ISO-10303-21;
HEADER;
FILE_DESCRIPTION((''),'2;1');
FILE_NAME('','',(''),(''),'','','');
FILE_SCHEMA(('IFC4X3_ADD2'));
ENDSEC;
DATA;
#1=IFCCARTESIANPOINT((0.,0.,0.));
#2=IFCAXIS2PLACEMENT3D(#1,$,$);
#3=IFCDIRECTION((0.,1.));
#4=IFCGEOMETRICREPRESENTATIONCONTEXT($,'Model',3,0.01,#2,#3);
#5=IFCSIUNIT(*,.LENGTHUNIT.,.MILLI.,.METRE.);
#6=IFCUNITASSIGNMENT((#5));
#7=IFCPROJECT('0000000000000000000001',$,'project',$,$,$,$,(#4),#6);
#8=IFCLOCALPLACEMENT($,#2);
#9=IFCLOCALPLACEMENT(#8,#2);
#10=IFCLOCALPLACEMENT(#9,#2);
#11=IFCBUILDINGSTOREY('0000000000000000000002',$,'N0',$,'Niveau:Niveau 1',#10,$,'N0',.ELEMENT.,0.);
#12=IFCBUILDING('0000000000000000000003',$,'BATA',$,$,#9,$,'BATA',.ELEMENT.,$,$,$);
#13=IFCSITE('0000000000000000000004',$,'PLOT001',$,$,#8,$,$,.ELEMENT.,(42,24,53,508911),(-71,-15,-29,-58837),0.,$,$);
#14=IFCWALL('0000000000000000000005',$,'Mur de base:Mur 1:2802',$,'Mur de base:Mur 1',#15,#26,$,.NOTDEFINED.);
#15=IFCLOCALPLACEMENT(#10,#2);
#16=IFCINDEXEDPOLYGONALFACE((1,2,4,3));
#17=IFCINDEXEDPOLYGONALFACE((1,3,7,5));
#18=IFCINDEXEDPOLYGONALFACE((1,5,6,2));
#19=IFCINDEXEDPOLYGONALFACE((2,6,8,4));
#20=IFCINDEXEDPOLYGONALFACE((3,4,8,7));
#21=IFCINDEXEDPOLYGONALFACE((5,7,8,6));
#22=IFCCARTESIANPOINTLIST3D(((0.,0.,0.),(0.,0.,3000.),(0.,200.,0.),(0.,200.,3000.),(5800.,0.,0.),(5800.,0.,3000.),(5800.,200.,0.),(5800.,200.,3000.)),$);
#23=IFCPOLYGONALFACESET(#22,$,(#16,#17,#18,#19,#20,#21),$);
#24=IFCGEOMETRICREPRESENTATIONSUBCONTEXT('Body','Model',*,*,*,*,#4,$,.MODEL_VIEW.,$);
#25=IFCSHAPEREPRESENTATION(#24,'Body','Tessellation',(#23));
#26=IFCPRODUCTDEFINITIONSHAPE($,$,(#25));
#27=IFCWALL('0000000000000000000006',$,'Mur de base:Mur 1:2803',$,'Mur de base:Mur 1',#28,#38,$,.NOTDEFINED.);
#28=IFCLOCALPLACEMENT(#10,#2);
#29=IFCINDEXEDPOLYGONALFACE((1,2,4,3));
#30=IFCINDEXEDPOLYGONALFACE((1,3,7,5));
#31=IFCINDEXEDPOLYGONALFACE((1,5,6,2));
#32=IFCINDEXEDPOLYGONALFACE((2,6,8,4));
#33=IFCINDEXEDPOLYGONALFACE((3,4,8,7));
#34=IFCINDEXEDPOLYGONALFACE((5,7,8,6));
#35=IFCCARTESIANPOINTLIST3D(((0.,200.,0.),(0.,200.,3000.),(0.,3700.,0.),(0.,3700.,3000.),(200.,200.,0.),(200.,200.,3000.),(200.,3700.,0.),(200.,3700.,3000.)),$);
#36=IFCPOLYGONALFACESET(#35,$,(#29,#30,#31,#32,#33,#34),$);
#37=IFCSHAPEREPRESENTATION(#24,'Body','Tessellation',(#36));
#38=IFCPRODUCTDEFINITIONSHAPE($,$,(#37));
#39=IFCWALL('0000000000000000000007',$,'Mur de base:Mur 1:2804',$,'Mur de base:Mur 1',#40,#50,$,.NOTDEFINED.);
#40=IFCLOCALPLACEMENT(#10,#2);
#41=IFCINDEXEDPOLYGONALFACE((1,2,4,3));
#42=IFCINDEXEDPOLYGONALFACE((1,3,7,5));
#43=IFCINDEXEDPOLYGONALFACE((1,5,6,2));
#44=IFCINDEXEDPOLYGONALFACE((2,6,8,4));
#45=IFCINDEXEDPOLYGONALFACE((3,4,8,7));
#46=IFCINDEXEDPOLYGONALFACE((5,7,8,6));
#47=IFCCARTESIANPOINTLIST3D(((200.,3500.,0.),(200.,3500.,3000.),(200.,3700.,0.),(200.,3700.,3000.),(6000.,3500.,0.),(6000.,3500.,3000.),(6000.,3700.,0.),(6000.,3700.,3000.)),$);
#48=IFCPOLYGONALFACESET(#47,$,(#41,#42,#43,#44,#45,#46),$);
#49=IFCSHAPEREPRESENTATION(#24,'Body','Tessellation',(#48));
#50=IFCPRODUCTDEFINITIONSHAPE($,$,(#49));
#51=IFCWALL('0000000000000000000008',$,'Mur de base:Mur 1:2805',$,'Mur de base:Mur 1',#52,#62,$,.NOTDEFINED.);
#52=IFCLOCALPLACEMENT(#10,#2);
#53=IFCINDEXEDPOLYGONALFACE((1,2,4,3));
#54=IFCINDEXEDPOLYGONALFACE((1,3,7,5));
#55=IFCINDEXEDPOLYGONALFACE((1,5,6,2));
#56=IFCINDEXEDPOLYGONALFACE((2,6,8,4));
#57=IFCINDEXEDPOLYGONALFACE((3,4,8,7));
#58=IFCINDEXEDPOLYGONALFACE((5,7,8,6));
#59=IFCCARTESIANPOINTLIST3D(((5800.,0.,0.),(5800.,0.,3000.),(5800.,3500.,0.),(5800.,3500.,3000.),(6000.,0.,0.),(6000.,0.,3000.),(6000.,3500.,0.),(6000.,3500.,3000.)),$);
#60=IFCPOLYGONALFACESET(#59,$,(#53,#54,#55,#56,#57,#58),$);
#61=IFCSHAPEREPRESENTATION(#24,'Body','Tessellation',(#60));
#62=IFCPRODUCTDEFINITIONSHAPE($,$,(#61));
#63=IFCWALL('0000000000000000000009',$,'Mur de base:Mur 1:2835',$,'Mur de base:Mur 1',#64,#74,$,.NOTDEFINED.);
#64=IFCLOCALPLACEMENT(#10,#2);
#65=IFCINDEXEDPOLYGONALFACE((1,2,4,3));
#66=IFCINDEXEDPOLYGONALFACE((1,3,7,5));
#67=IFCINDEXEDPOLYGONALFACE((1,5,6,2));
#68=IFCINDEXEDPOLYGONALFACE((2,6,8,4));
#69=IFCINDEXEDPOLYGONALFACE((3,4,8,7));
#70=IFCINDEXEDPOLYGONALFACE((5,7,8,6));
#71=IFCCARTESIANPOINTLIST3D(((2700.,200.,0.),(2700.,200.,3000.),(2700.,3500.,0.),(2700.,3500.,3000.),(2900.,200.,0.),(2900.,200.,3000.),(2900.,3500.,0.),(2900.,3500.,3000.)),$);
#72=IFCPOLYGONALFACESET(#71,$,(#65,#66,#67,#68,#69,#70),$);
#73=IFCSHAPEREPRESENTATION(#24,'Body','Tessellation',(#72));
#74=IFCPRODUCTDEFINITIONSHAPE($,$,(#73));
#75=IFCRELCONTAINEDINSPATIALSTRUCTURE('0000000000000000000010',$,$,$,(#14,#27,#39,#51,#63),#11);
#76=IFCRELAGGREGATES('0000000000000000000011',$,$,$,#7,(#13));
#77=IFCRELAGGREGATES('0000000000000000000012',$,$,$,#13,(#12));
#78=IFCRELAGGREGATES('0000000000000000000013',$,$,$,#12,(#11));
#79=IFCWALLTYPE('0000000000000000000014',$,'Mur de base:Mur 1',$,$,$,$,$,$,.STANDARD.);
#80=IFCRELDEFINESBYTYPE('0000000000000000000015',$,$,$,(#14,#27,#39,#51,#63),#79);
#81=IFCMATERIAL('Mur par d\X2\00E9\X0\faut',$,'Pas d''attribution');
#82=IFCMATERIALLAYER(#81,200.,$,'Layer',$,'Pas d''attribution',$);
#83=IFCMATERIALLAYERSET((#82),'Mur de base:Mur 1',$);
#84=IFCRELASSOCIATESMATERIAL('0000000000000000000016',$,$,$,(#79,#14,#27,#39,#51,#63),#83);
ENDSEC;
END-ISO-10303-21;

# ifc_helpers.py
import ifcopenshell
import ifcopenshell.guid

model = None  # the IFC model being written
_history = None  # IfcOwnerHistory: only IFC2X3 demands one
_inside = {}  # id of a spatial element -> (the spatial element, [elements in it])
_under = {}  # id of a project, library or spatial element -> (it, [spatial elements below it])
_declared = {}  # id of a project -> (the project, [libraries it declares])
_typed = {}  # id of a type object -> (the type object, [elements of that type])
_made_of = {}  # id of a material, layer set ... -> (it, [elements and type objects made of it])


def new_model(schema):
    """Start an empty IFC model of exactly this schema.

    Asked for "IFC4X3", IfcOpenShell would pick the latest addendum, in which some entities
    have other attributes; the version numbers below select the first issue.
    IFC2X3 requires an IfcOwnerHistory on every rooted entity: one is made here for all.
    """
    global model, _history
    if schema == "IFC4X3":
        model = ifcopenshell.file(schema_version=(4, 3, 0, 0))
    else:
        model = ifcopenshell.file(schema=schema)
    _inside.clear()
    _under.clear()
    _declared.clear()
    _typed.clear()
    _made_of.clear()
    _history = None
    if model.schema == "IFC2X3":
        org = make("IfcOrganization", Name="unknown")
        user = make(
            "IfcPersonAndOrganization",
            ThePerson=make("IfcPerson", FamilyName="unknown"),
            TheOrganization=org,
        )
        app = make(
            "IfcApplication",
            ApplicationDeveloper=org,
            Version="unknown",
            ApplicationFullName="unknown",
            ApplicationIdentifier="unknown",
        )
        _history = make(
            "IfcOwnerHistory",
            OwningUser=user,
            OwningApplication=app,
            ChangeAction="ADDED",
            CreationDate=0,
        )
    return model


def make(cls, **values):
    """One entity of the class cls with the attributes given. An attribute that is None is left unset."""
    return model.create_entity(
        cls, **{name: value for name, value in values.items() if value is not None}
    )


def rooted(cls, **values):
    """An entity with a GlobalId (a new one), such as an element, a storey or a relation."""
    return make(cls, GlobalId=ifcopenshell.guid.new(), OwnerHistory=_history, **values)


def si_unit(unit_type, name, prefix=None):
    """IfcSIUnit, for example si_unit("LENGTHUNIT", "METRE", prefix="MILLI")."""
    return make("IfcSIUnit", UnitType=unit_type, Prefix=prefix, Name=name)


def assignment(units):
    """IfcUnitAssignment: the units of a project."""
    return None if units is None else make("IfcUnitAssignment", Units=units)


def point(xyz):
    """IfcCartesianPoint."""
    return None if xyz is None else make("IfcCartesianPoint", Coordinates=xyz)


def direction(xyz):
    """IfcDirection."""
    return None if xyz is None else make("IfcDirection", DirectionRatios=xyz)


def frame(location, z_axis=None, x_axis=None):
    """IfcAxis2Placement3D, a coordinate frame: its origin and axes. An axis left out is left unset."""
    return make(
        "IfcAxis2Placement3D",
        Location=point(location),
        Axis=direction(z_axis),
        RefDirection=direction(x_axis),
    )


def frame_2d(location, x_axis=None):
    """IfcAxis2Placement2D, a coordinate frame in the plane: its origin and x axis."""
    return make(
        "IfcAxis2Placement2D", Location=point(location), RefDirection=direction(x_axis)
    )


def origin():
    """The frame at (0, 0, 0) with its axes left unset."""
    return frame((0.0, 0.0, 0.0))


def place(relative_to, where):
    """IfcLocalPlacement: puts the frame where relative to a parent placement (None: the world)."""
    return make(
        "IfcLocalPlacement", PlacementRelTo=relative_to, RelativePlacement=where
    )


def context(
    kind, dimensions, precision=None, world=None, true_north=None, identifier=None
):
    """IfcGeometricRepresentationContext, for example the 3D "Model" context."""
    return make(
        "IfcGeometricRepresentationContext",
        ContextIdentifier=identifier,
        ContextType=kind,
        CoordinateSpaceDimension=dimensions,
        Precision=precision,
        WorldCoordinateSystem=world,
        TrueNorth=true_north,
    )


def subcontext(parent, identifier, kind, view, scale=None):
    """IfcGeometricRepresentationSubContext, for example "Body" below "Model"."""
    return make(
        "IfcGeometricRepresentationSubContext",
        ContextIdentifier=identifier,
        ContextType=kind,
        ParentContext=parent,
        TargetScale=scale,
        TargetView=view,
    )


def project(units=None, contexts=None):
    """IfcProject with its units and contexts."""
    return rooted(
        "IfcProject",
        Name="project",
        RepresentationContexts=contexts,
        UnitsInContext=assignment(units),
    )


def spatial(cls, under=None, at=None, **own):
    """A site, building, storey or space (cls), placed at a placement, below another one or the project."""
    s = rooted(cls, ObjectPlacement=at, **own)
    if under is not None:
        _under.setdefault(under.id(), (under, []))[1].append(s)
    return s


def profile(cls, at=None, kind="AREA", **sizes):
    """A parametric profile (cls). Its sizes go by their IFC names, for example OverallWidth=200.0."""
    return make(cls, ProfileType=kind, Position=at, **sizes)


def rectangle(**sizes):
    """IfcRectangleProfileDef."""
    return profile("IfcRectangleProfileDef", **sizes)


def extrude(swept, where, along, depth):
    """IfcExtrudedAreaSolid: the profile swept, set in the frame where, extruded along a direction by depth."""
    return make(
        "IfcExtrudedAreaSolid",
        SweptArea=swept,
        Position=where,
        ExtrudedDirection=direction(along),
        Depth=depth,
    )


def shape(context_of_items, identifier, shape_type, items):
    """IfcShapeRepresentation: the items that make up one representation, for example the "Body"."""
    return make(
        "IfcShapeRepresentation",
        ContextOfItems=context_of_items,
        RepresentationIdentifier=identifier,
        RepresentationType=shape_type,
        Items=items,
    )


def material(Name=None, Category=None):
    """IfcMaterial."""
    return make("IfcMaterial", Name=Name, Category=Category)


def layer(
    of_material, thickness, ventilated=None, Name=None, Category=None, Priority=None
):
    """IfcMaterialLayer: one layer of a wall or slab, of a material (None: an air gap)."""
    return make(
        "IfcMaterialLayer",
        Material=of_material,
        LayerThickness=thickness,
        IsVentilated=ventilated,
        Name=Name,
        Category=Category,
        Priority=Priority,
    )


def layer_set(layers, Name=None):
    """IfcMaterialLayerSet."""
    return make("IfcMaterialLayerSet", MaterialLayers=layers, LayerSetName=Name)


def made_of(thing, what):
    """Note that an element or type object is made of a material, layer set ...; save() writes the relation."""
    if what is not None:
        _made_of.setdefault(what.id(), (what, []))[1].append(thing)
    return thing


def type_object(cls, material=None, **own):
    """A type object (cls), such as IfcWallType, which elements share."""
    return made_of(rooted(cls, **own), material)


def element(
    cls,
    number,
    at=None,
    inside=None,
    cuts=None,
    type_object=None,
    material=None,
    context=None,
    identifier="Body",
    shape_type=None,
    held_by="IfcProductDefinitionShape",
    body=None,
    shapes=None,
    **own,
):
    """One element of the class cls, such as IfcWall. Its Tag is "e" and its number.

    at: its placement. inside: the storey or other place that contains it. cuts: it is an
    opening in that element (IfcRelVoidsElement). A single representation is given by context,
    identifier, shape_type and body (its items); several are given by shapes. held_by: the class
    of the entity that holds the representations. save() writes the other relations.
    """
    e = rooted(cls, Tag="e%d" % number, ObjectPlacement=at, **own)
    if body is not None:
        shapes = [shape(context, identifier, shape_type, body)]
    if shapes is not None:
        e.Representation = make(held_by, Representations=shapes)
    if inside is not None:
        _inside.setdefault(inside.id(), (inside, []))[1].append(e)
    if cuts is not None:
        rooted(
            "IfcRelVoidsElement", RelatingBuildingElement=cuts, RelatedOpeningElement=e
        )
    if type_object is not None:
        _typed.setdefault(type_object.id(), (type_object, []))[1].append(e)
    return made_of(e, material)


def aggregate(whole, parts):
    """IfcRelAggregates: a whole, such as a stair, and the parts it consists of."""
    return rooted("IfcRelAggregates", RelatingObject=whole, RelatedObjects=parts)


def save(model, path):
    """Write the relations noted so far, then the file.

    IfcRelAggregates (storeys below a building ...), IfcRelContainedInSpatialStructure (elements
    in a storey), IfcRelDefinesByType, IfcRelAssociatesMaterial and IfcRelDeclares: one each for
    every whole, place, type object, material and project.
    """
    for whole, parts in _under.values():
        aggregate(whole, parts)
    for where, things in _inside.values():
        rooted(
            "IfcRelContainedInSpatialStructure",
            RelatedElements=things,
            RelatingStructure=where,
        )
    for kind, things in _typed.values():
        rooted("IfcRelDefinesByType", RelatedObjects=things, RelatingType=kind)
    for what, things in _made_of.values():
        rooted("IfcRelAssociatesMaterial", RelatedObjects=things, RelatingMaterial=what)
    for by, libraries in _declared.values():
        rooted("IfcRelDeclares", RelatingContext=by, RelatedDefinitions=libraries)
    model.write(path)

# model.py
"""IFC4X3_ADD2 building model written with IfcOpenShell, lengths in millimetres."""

from ifc_helpers import new_model, si_unit, direction, frame, frame_2d, origin, place, context, subcontext, project, spatial, rectangle, extrude, material, layer, layer_set, type_object, element, save


model = new_model("IFC4X3_ADD2")

# Units and contexts
model_context = context("Model", 3, precision=0.01, world=origin(), true_north=direction((0.0, 1.0)))
body_context = subcontext(model_context, "Body", "Model", "MODEL_VIEW")
ifc_project = project(units=[si_unit("LENGTHUNIT", "METRE", prefix="MILLI")], contexts=[model_context])

# Site, building, storey
site_placement = place(None, origin())
site = spatial("IfcSite", under=ifc_project, at=site_placement, Name="PLOT001", CompositionType="ELEMENT", RefLatitude=(42, 24, 53, 508911), RefLongitude=(-71, -15, -29, -58837), RefElevation=0.0)
building_placement = place(site_placement, origin())
building = spatial("IfcBuilding", under=site, at=building_placement, Name="BATA", LongName="BATA", CompositionType="ELEMENT")
storey_placement = place(building_placement, origin())
storey = spatial("IfcBuildingStorey", under=building, at=storey_placement, Name="N0", ObjectType="Niveau:Niveau 1", LongName="N0", CompositionType="ELEMENT", Elevation=0.0)

# Walls
ifc_material = material(Name="Mur par défaut", Category="Pas d'attribution")
ifc_layer = layer(ifc_material, 200.0, Name="Layer", Category="Pas d'attribution")
ifc_layer_set = layer_set([ifc_layer], Name="Mur de base:Mur 1")
wall_type = type_object("IfcWallType", Name="Mur de base:Mur 1", PredefinedType="STANDARD", material=ifc_layer_set)
wall_1_placement = place(storey_placement, frame((0.0, 100.0, 0.0)))
element("IfcWall", 1, at=wall_1_placement, inside=storey, type_object=wall_type, material=ifc_layer_set, Name="Mur de base:Mur 1:2802", ObjectType="Mur de base:Mur 1", PredefinedType="NOTDEFINED", context=body_context, shape_type="SweptSolid", body=[
    extrude(rectangle(XDim=5800.0, YDim=200.0, at=frame_2d((2900.0, 0.0), x_axis=(-1.0, 0.0))), origin(), (0.0, 0.0, 1.0), 3000.0),
])
wall_2_placement = place(storey_placement, frame((100.0, 3700.0, 0.0), z_axis=(0.0, 0.0, 1.0), x_axis=(0.0, -1.0, 0.0)))
element("IfcWall", 2, at=wall_2_placement, inside=storey, type_object=wall_type, material=ifc_layer_set, Name="Mur de base:Mur 1:2803", ObjectType="Mur de base:Mur 1", PredefinedType="NOTDEFINED", context=body_context, shape_type="SweptSolid", body=[
    extrude(rectangle(XDim=3500.0, YDim=200.0, at=frame_2d((1750.0, 0.0), x_axis=(-1.0, 0.0))), origin(), (0.0, 0.0, 1.0), 3000.0),
])
wall_3_placement = place(storey_placement, frame((6000.0, 3600.0, 0.0), z_axis=(0.0, 0.0, 1.0), x_axis=(-1.0, 0.0, 0.0)))
element("IfcWall", 3, at=wall_3_placement, inside=storey, type_object=wall_type, material=ifc_layer_set, Name="Mur de base:Mur 1:2804", ObjectType="Mur de base:Mur 1", PredefinedType="NOTDEFINED", context=body_context, shape_type="SweptSolid", body=[
    extrude(rectangle(XDim=5800.0, YDim=200.0, at=frame_2d((2900.0, 0.0), x_axis=(-1.0, 0.0))), origin(), (0.0, 0.0, 1.0), 3000.0),
])
wall_4_placement = place(storey_placement, frame((5900.0, 0.0, 0.0), z_axis=(0.0, 0.0, 1.0), x_axis=(0.0, 1.0, 0.0)))
element("IfcWall", 4, at=wall_4_placement, inside=storey, type_object=wall_type, material=ifc_layer_set, Name="Mur de base:Mur 1:2805", ObjectType="Mur de base:Mur 1", PredefinedType="NOTDEFINED", context=body_context, shape_type="SweptSolid", body=[
    extrude(rectangle(XDim=3500.0, YDim=200.0, at=frame_2d((1750.0, 0.0), x_axis=(-1.0, 0.0))), origin(), (0.0, 0.0, 1.0), 3000.0),
])
wall_5_placement = place(storey_placement, frame((2800.0, 200.0, 0.0), z_axis=(0.0, 0.0, 1.0), x_axis=(0.0, 1.0, 0.0)))
element("IfcWall", 5, at=wall_5_placement, inside=storey, type_object=wall_type, material=ifc_layer_set, Name="Mur de base:Mur 1:2835", ObjectType="Mur de base:Mur 1", PredefinedType="NOTDEFINED", context=body_context, shape_type="SweptSolid", body=[
    extrude(rectangle(XDim=3300.0, YDim=200.0, at=frame_2d((1650.0, 0.0), x_axis=(-1.0, 0.0))), origin(), (0.0, 0.0, 1.0), 3000.0),
])

save(model, "model.ifc")
